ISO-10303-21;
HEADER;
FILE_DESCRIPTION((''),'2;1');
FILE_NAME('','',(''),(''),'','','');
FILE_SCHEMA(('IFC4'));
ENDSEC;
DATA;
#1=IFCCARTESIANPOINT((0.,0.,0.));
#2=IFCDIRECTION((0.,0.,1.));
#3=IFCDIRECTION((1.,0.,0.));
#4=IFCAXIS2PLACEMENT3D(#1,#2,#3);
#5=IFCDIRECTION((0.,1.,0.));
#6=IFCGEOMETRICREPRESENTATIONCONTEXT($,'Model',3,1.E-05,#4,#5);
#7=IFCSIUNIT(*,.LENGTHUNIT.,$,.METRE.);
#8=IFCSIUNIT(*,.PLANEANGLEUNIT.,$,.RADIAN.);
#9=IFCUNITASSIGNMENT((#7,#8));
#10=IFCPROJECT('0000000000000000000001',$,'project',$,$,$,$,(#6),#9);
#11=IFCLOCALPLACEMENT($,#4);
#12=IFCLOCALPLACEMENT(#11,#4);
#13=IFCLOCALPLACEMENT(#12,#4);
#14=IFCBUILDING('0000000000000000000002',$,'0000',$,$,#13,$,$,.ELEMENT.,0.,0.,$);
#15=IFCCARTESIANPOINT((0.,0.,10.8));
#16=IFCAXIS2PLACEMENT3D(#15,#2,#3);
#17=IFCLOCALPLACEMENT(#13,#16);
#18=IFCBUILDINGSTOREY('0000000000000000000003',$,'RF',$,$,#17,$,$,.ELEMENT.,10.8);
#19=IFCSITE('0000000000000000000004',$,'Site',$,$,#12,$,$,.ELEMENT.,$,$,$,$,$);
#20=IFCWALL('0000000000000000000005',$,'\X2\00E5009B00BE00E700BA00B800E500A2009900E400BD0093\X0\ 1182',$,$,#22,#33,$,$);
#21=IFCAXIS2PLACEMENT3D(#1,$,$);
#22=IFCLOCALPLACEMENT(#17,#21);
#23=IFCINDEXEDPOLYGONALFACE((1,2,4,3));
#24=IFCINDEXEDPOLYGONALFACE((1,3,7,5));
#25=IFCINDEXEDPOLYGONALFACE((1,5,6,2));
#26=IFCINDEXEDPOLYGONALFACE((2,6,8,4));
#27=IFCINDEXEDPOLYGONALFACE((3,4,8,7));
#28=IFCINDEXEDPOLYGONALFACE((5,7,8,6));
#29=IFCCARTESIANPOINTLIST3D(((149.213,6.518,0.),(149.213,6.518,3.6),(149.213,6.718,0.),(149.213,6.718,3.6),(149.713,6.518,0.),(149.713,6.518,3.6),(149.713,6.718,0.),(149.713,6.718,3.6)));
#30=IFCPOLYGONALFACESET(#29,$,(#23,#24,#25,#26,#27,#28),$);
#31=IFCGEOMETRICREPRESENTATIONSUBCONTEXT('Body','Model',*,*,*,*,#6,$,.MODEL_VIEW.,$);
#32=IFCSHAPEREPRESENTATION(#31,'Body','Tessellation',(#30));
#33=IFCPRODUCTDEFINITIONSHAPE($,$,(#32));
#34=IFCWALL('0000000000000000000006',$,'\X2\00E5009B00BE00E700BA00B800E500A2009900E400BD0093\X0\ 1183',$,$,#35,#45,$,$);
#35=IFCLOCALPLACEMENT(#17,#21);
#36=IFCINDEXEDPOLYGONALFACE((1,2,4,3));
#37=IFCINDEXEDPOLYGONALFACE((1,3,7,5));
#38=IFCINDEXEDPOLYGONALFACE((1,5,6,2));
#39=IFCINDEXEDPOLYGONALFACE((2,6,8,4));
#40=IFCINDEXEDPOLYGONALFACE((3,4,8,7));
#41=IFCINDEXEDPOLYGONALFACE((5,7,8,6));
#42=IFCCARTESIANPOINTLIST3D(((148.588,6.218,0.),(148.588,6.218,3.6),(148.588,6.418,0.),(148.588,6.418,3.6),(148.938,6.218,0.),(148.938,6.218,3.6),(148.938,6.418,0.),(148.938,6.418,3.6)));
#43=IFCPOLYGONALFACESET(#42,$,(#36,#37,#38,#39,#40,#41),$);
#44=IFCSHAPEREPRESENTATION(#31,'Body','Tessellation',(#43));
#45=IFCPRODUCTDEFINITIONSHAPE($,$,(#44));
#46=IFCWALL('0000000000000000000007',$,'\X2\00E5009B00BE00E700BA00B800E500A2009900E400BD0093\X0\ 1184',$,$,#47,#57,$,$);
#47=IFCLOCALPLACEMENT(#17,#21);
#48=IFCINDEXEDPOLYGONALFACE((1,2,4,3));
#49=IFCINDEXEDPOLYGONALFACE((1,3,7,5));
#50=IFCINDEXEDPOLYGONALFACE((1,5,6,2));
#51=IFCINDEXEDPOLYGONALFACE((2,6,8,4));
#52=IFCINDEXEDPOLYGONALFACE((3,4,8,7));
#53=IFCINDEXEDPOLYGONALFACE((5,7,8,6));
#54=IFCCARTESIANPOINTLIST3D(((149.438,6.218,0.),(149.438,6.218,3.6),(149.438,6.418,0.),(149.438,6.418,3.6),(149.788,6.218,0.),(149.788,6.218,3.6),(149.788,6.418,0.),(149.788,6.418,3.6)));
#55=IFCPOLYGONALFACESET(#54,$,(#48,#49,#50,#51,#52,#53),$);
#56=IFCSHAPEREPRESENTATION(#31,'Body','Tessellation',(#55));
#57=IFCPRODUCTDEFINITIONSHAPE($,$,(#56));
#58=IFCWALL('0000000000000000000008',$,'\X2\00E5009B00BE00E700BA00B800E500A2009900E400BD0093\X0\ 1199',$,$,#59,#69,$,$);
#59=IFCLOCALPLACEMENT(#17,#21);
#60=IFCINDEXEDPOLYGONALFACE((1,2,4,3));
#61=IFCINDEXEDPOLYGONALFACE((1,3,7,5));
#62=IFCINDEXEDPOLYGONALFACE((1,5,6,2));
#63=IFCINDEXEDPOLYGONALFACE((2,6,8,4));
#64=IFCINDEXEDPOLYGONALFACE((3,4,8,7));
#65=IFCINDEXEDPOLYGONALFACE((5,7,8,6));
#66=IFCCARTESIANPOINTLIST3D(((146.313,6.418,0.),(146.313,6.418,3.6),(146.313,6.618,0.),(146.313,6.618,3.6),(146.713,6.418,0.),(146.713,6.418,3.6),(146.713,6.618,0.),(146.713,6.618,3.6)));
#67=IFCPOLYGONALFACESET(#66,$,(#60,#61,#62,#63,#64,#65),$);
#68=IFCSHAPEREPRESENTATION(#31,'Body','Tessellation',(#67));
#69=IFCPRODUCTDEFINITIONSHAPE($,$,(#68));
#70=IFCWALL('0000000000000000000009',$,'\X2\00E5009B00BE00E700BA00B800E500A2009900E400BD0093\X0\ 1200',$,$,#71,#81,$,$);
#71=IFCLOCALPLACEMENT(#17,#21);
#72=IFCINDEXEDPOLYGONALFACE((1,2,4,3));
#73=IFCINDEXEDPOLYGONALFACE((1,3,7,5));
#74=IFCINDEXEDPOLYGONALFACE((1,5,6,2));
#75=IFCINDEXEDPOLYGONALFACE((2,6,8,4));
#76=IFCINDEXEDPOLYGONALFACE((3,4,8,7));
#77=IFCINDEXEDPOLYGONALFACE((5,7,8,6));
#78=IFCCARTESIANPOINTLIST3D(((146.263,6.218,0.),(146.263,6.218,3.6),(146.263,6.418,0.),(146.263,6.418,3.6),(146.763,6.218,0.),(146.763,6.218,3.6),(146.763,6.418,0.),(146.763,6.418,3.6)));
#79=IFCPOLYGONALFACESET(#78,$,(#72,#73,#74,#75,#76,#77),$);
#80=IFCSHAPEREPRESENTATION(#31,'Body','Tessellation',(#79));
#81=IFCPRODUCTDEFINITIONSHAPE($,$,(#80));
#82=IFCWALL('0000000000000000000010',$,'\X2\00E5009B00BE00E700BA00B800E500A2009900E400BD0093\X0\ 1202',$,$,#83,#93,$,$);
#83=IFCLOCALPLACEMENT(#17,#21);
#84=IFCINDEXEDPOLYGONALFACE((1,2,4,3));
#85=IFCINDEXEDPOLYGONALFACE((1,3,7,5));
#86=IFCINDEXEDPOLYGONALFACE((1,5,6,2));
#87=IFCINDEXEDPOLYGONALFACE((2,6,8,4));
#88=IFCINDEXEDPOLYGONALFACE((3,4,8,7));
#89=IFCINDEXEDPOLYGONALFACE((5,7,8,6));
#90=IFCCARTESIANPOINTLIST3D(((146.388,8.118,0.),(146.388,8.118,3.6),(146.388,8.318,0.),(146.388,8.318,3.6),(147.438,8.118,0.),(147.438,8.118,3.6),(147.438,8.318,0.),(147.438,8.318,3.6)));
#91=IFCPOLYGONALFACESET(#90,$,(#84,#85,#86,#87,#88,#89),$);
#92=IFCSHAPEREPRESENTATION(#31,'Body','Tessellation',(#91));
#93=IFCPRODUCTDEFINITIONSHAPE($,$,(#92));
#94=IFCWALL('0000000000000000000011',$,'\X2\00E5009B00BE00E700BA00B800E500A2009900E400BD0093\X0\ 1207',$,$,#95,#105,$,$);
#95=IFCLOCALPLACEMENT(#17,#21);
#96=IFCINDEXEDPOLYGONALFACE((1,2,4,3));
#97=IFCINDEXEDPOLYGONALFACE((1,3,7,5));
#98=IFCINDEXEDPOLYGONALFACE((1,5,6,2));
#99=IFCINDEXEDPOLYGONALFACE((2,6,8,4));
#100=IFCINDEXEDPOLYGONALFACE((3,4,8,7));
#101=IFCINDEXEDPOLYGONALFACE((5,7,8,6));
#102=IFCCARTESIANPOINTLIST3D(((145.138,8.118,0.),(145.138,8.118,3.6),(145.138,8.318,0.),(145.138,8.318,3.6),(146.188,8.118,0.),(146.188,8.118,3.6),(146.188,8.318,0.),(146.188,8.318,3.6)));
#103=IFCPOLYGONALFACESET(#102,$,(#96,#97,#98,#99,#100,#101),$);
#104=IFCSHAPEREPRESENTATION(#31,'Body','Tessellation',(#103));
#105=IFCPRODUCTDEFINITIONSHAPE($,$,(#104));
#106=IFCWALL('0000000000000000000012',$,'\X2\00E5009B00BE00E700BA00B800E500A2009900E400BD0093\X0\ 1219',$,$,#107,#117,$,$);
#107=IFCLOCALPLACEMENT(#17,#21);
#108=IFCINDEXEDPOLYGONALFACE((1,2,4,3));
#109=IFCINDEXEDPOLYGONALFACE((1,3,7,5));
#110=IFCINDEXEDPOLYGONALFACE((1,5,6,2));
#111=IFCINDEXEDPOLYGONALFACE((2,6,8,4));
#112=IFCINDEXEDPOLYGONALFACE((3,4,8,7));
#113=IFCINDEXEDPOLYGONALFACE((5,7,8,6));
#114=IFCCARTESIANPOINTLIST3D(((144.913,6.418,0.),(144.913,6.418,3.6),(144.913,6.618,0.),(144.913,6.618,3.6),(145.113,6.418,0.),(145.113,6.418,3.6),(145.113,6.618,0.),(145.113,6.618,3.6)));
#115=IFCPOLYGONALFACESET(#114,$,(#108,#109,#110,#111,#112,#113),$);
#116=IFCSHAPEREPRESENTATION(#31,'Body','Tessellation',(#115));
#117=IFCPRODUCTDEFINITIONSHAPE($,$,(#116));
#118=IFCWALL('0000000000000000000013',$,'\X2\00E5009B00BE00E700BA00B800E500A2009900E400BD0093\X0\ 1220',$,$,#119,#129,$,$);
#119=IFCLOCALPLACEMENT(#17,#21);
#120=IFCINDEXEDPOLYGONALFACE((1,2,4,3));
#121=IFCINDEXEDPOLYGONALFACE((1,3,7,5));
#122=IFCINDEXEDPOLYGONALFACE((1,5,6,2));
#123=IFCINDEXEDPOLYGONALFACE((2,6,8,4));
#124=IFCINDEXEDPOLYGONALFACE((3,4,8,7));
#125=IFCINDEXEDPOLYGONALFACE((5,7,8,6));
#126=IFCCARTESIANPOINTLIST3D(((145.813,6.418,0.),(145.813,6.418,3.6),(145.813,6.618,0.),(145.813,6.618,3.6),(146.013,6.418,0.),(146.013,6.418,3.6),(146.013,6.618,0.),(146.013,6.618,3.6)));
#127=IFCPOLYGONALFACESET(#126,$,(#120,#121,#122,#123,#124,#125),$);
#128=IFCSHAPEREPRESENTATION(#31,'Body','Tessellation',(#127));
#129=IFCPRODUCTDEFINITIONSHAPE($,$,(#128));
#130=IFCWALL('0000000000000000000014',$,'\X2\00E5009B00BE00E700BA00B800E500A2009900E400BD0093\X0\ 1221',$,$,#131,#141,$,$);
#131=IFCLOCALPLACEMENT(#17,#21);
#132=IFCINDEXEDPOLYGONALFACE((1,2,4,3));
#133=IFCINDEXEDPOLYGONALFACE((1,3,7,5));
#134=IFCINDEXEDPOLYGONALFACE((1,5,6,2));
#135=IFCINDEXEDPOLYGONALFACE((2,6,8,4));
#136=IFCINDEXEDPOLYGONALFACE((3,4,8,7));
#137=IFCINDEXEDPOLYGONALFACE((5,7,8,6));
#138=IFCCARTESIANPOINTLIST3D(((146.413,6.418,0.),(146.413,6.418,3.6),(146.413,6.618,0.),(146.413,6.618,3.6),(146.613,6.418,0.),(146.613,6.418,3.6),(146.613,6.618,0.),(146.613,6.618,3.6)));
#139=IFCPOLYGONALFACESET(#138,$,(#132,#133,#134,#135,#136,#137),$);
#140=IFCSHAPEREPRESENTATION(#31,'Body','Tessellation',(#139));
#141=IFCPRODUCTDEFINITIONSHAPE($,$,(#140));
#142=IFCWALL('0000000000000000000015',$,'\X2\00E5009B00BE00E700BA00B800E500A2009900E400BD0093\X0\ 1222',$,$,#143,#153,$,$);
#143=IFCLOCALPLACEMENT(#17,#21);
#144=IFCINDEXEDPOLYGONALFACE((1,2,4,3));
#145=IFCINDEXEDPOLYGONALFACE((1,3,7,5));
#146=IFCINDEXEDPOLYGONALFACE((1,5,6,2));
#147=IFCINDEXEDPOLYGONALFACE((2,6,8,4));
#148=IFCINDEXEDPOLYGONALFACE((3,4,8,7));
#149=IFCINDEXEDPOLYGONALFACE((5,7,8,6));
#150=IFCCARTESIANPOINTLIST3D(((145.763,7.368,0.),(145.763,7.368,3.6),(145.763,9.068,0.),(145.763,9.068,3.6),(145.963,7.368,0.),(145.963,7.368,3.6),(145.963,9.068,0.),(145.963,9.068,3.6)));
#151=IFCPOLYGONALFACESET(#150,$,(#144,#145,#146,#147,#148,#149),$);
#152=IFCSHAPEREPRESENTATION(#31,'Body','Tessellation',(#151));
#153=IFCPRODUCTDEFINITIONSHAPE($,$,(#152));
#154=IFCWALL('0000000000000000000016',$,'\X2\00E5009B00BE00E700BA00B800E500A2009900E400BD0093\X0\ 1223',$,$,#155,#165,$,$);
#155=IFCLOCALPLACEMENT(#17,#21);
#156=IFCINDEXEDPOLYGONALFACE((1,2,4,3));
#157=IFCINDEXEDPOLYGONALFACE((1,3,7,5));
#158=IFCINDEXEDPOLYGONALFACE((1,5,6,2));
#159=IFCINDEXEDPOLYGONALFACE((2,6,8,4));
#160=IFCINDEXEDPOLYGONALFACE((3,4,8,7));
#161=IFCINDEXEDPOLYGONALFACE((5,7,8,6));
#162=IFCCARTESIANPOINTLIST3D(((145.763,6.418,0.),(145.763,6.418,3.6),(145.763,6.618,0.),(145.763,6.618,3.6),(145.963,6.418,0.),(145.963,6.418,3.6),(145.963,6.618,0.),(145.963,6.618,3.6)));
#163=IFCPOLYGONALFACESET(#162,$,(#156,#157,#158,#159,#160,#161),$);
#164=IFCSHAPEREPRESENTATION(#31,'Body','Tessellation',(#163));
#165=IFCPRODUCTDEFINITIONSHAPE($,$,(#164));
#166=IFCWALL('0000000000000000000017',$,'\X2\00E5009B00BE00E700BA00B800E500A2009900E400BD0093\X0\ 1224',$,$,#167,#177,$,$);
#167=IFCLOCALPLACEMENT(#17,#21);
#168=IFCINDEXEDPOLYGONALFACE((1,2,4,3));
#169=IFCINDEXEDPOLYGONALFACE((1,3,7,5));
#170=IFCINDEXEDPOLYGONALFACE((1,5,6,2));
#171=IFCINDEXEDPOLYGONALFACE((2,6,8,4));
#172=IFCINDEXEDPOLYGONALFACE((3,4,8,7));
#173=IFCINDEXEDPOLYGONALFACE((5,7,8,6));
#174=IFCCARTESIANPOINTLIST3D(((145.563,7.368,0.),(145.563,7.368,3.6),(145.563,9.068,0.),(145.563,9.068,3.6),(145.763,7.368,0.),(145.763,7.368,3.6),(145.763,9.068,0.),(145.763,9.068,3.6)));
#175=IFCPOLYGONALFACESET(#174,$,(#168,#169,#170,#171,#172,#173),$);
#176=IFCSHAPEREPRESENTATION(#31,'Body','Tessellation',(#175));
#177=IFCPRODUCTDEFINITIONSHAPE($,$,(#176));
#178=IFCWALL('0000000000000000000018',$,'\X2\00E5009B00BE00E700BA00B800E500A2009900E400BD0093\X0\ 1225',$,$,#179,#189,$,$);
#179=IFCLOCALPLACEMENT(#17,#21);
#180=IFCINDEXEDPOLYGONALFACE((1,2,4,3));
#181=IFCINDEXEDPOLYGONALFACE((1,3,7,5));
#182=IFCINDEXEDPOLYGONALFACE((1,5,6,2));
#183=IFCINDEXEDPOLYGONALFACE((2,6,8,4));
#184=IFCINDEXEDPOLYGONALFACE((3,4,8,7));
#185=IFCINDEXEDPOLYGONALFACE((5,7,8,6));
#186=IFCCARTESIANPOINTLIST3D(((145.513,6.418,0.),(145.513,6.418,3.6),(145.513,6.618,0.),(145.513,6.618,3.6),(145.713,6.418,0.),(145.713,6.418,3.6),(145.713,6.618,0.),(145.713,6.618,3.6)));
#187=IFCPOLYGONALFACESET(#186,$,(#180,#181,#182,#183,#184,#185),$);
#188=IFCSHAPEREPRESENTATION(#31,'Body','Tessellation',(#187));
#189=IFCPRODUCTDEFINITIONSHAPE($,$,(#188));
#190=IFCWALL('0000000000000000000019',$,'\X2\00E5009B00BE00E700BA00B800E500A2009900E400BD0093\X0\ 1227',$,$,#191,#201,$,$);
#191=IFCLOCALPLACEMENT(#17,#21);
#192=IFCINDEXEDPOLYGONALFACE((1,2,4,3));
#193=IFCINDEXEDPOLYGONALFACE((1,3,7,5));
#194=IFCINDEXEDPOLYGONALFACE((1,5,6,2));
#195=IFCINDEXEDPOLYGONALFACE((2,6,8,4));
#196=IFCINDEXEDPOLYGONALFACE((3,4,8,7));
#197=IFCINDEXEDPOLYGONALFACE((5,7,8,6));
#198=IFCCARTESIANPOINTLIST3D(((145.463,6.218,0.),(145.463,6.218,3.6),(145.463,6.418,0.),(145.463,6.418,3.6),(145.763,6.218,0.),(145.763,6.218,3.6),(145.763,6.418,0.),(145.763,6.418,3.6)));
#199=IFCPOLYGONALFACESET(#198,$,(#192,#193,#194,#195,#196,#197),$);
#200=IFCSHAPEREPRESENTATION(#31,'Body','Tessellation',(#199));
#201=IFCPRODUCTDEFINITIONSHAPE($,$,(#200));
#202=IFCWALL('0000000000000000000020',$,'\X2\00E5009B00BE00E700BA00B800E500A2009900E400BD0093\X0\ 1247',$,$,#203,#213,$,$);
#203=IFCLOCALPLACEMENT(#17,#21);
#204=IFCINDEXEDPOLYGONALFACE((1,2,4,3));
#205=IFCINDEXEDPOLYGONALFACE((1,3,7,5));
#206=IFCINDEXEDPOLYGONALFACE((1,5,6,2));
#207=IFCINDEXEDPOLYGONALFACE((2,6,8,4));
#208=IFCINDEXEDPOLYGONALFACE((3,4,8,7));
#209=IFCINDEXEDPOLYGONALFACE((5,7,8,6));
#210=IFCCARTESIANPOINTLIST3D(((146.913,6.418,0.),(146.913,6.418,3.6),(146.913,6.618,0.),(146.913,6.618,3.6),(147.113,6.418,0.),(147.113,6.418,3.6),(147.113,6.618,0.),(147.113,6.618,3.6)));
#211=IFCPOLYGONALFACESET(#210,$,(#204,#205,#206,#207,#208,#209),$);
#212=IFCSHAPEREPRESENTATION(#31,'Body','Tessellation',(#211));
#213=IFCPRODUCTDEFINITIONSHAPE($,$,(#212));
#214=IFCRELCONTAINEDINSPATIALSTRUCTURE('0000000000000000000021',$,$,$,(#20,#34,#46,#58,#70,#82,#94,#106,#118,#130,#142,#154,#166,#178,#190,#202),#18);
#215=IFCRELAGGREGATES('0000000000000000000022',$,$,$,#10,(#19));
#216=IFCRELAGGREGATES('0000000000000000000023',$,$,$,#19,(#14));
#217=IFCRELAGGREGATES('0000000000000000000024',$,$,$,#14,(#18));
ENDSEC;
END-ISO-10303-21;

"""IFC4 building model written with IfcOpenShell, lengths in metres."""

from ifc_helpers import new_model, si_unit, direction, frame, frame_2d, origin_with_axes, place, context, subcontext, project, spatial, rectangle, extrude, element, save


model = new_model("IFC4")

# Units and contexts
model_context = context("Model", 3, precision=1e-05, world=origin_with_axes(), true_north=direction((0.0, 1.0, 0.0)))
body_context = subcontext(model_context, "Body", "Model", "MODEL_VIEW")
ifc_project = project(units=[si_unit("LENGTHUNIT", "METRE"), si_unit("PLANEANGLEUNIT", "RADIAN")], contexts=[model_context])

# Site, building, storey
placement = place(None, origin_with_axes())
site_placement = place(placement, origin_with_axes())
site = spatial("IfcSite", under=ifc_project, at=site_placement, Name="Site", CompositionType="ELEMENT")
building_placement = place(site_placement, origin_with_axes())
building = spatial("IfcBuilding", under=site, at=building_placement, Name="0000", CompositionType="ELEMENT", ElevationOfRefHeight=0.0, ElevationOfTerrain=0.0)
storey_placement = place(building_placement, frame((0.0, 0.0, 10.8), z_axis=(0.0, 0.0, 1.0), x_axis=(1.0, 0.0, 0.0)))
storey = spatial("IfcBuildingStorey", under=building, at=storey_placement, Name="RF", CompositionType="ELEMENT", Elevation=10.8)

# Walls
wall_1_placement = place(storey_placement, frame((149.463, 6.618, 0.0), z_axis=(0.0, 0.0, 1.0), x_axis=(1.0, 0.0, 0.0)))
element("IfcWall", 1, at=wall_1_placement, inside=storey, Name="å\u009b¾çº¸å¢\u0099ä½\u0093 1182", context=body_context, shape_type="SweptSolid", body=[
    extrude(rectangle(XDim=0.5, YDim=0.2, at=frame_2d((0.0, 0.0), x_axis=(1.0, 0.0, 0.0))), frame((0.0, 0.0, 0.0), z_axis=(0.0, 0.0, 1.0)), (0.0, 0.0, 1.0), 3.6),
])
for number, where, z_axis, x_axis, name in (
    (2, (148.763, 6.318, 0.0), (0.0, 0.0, 1.0), (1.0, 0.0, 0.0), "å\u009b¾çº¸å¢\u0099ä½\u0093 1183"),
    (3, (149.613, 6.318, 0.0), (0.0, 0.0, 1.0), (1.0, 0.0, 0.0), "å\u009b¾çº¸å¢\u0099ä½\u0093 1184"),
):
    element("IfcWall", number, at=place(storey_placement, frame(where, z_axis=z_axis, x_axis=x_axis)), inside=storey, Name=name, context=body_context, shape_type="SweptSolid", body=[
        extrude(rectangle(XDim=0.35, YDim=0.2, at=frame_2d((0.0, 0.0), x_axis=(1.0, 0.0, 0.0))), frame((0.0, 0.0, 0.0), z_axis=(0.0, 0.0, 1.0)), (0.0, 0.0, 1.0), 3.6),
    ])
wall_2_placement = place(storey_placement, frame((146.513, 6.518, 0.0), z_axis=(0.0, 0.0, 1.0), x_axis=(1.0, 0.0, 0.0)))
element("IfcWall", 4, at=wall_2_placement, inside=storey, Name="å\u009b¾çº¸å¢\u0099ä½\u0093 1199", context=body_context, shape_type="SweptSolid", body=[
    extrude(rectangle(XDim=0.4, YDim=0.2, at=frame_2d((0.0, 0.0), x_axis=(1.0, 0.0, 0.0))), frame((0.0, 0.0, 0.0), z_axis=(0.0, 0.0, 1.0)), (0.0, 0.0, 1.0), 3.6),
])
wall_3_placement = place(storey_placement, frame((146.513, 6.318, 0.0), z_axis=(0.0, 0.0, 1.0), x_axis=(1.0, 0.0, 0.0)))
element("IfcWall", 5, at=wall_3_placement, inside=storey, Name="å\u009b¾çº¸å¢\u0099ä½\u0093 1200", context=body_context, shape_type="SweptSolid", body=[
    extrude(rectangle(XDim=0.5, YDim=0.2, at=frame_2d((0.0, 0.0), x_axis=(1.0, 0.0, 0.0))), frame((0.0, 0.0, 0.0), z_axis=(0.0, 0.0, 1.0)), (0.0, 0.0, 1.0), 3.6),
])
for number, where, z_axis, x_axis, name in (
    (6, (146.913, 8.218, 0.0), (0.0, 0.0, 1.0), (-1.0, 0.0, 0.0), "å\u009b¾çº¸å¢\u0099ä½\u0093 1202"),
    (7, (145.663, 8.218, 0.0), (0.0, 0.0, 1.0), (-1.0, 0.0, 0.0), "å\u009b¾çº¸å¢\u0099ä½\u0093 1207"),
):
    element("IfcWall", number, at=place(storey_placement, frame(where, z_axis=z_axis, x_axis=x_axis)), inside=storey, Name=name, context=body_context, shape_type="SweptSolid", body=[
        extrude(rectangle(XDim=1.05, YDim=0.2, at=frame_2d((0.0, 0.0), x_axis=(1.0, 0.0, 0.0))), frame((0.0, 0.0, 0.0), z_axis=(0.0, 0.0, 1.0)), (0.0, 0.0, 1.0), 3.6),
    ])
for number, where, z_axis, x_axis, name in (
    (8, (145.013, 6.518, 0.0), (0.0, 0.0, 1.0), (0.0, -1.0, 0.0), "å\u009b¾çº¸å¢\u0099ä½\u0093 1219"),
    (9, (145.913, 6.518, 0.0), (0.0, 0.0, 1.0), (0.0, -1.0, 0.0), "å\u009b¾çº¸å¢\u0099ä½\u0093 1220"),
    (10, (146.513, 6.518, 0.0), (0.0, 0.0, 1.0), (0.0, -1.0, 0.0), "å\u009b¾çº¸å¢\u0099ä½\u0093 1221"),
):
    element("IfcWall", number, at=place(storey_placement, frame(where, z_axis=z_axis, x_axis=x_axis)), inside=storey, Name=name, context=body_context, shape_type="SweptSolid", body=[
        extrude(rectangle(XDim=0.2, YDim=0.2, at=frame_2d((0.0, 0.0), x_axis=(1.0, 0.0, 0.0))), frame((0.0, 0.0, 0.0), z_axis=(0.0, 0.0, 1.0)), (0.0, 0.0, 1.0), 3.6),
    ])
wall_4_placement = place(storey_placement, frame((145.863, 8.218, 0.0), z_axis=(0.0, 0.0, 1.0), x_axis=(0.0, -1.0, 0.0)))
element("IfcWall", 11, at=wall_4_placement, inside=storey, Name="å\u009b¾çº¸å¢\u0099ä½\u0093 1222", context=body_context, shape_type="SweptSolid", body=[
    extrude(rectangle(XDim=1.7, YDim=0.2, at=frame_2d((0.0, 0.0), x_axis=(1.0, 0.0, 0.0))), frame((0.0, 0.0, 0.0), z_axis=(0.0, 0.0, 1.0)), (0.0, 0.0, 1.0), 3.6),
])
wall_5_placement = place(storey_placement, frame((145.863, 6.518, 0.0), z_axis=(0.0, 0.0, 1.0), x_axis=(1.0, 0.0, 0.0)))
element("IfcWall", 12, at=wall_5_placement, inside=storey, Name="å\u009b¾çº¸å¢\u0099ä½\u0093 1223", context=body_context, shape_type="SweptSolid", body=[
    extrude(rectangle(XDim=0.2, YDim=0.2, at=frame_2d((0.0, 0.0), x_axis=(1.0, 0.0, 0.0))), frame((0.0, 0.0, 0.0), z_axis=(0.0, 0.0, 1.0)), (0.0, 0.0, 1.0), 3.6),
])
wall_6_placement = place(storey_placement, frame((145.663, 8.218, 0.0), z_axis=(0.0, 0.0, 1.0), x_axis=(0.0, -1.0, 0.0)))
element("IfcWall", 13, at=wall_6_placement, inside=storey, Name="å\u009b¾çº¸å¢\u0099ä½\u0093 1224", context=body_context, shape_type="SweptSolid", body=[
    extrude(rectangle(XDim=1.7, YDim=0.2, at=frame_2d((0.0, 0.0), x_axis=(1.0, 0.0, 0.0))), frame((0.0, 0.0, 0.0), z_axis=(0.0, 0.0, 1.0)), (0.0, 0.0, 1.0), 3.6),
])
for number, where, z_axis, x_axis, name in (
    (14, (145.613, 6.518, 0.0), (0.0, 0.0, 1.0), (1.0, 0.0, 0.0), "å\u009b¾çº¸å¢\u0099ä½\u0093 1225"),
):
    element("IfcWall", number, at=place(storey_placement, frame(where, z_axis=z_axis, x_axis=x_axis)), inside=storey, Name=name, context=body_context, shape_type="SweptSolid", body=[
        extrude(rectangle(XDim=0.2, YDim=0.2, at=frame_2d((0.0, 0.0), x_axis=(1.0, 0.0, 0.0))), frame((0.0, 0.0, 0.0), z_axis=(0.0, 0.0, 1.0)), (0.0, 0.0, 1.0), 3.6),
    ])
wall_7_placement = place(storey_placement, frame((145.613, 6.318, 0.0), z_axis=(0.0, 0.0, 1.0), x_axis=(1.0, 0.0, 0.0)))
element("IfcWall", 15, at=wall_7_placement, inside=storey, Name="å\u009b¾çº¸å¢\u0099ä½\u0093 1227", context=body_context, shape_type="SweptSolid", body=[
    extrude(rectangle(XDim=0.3, YDim=0.2, at=frame_2d((0.0, 0.0), x_axis=(1.0, 0.0, 0.0))), frame((0.0, 0.0, 0.0), z_axis=(0.0, 0.0, 1.0)), (0.0, 0.0, 1.0), 3.6),
])
for number, where, z_axis, x_axis, name in (
    (16, (147.013, 6.518, 0.0), (0.0, 0.0, 1.0), (0.0, -1.0, 0.0), "å\u009b¾çº¸å¢\u0099ä½\u0093 1247"),
):
    element("IfcWall", number, at=place(storey_placement, frame(where, z_axis=z_axis, x_axis=x_axis)), inside=storey, Name=name, context=body_context, shape_type="SweptSolid", body=[
        extrude(rectangle(XDim=0.2, YDim=0.2, at=frame_2d((0.0, 0.0), x_axis=(1.0, 0.0, 0.0))), frame((0.0, 0.0, 0.0), z_axis=(0.0, 0.0, 1.0)), (0.0, 0.0, 1.0), 3.6),
    ])

save(model, "model.ifc")
